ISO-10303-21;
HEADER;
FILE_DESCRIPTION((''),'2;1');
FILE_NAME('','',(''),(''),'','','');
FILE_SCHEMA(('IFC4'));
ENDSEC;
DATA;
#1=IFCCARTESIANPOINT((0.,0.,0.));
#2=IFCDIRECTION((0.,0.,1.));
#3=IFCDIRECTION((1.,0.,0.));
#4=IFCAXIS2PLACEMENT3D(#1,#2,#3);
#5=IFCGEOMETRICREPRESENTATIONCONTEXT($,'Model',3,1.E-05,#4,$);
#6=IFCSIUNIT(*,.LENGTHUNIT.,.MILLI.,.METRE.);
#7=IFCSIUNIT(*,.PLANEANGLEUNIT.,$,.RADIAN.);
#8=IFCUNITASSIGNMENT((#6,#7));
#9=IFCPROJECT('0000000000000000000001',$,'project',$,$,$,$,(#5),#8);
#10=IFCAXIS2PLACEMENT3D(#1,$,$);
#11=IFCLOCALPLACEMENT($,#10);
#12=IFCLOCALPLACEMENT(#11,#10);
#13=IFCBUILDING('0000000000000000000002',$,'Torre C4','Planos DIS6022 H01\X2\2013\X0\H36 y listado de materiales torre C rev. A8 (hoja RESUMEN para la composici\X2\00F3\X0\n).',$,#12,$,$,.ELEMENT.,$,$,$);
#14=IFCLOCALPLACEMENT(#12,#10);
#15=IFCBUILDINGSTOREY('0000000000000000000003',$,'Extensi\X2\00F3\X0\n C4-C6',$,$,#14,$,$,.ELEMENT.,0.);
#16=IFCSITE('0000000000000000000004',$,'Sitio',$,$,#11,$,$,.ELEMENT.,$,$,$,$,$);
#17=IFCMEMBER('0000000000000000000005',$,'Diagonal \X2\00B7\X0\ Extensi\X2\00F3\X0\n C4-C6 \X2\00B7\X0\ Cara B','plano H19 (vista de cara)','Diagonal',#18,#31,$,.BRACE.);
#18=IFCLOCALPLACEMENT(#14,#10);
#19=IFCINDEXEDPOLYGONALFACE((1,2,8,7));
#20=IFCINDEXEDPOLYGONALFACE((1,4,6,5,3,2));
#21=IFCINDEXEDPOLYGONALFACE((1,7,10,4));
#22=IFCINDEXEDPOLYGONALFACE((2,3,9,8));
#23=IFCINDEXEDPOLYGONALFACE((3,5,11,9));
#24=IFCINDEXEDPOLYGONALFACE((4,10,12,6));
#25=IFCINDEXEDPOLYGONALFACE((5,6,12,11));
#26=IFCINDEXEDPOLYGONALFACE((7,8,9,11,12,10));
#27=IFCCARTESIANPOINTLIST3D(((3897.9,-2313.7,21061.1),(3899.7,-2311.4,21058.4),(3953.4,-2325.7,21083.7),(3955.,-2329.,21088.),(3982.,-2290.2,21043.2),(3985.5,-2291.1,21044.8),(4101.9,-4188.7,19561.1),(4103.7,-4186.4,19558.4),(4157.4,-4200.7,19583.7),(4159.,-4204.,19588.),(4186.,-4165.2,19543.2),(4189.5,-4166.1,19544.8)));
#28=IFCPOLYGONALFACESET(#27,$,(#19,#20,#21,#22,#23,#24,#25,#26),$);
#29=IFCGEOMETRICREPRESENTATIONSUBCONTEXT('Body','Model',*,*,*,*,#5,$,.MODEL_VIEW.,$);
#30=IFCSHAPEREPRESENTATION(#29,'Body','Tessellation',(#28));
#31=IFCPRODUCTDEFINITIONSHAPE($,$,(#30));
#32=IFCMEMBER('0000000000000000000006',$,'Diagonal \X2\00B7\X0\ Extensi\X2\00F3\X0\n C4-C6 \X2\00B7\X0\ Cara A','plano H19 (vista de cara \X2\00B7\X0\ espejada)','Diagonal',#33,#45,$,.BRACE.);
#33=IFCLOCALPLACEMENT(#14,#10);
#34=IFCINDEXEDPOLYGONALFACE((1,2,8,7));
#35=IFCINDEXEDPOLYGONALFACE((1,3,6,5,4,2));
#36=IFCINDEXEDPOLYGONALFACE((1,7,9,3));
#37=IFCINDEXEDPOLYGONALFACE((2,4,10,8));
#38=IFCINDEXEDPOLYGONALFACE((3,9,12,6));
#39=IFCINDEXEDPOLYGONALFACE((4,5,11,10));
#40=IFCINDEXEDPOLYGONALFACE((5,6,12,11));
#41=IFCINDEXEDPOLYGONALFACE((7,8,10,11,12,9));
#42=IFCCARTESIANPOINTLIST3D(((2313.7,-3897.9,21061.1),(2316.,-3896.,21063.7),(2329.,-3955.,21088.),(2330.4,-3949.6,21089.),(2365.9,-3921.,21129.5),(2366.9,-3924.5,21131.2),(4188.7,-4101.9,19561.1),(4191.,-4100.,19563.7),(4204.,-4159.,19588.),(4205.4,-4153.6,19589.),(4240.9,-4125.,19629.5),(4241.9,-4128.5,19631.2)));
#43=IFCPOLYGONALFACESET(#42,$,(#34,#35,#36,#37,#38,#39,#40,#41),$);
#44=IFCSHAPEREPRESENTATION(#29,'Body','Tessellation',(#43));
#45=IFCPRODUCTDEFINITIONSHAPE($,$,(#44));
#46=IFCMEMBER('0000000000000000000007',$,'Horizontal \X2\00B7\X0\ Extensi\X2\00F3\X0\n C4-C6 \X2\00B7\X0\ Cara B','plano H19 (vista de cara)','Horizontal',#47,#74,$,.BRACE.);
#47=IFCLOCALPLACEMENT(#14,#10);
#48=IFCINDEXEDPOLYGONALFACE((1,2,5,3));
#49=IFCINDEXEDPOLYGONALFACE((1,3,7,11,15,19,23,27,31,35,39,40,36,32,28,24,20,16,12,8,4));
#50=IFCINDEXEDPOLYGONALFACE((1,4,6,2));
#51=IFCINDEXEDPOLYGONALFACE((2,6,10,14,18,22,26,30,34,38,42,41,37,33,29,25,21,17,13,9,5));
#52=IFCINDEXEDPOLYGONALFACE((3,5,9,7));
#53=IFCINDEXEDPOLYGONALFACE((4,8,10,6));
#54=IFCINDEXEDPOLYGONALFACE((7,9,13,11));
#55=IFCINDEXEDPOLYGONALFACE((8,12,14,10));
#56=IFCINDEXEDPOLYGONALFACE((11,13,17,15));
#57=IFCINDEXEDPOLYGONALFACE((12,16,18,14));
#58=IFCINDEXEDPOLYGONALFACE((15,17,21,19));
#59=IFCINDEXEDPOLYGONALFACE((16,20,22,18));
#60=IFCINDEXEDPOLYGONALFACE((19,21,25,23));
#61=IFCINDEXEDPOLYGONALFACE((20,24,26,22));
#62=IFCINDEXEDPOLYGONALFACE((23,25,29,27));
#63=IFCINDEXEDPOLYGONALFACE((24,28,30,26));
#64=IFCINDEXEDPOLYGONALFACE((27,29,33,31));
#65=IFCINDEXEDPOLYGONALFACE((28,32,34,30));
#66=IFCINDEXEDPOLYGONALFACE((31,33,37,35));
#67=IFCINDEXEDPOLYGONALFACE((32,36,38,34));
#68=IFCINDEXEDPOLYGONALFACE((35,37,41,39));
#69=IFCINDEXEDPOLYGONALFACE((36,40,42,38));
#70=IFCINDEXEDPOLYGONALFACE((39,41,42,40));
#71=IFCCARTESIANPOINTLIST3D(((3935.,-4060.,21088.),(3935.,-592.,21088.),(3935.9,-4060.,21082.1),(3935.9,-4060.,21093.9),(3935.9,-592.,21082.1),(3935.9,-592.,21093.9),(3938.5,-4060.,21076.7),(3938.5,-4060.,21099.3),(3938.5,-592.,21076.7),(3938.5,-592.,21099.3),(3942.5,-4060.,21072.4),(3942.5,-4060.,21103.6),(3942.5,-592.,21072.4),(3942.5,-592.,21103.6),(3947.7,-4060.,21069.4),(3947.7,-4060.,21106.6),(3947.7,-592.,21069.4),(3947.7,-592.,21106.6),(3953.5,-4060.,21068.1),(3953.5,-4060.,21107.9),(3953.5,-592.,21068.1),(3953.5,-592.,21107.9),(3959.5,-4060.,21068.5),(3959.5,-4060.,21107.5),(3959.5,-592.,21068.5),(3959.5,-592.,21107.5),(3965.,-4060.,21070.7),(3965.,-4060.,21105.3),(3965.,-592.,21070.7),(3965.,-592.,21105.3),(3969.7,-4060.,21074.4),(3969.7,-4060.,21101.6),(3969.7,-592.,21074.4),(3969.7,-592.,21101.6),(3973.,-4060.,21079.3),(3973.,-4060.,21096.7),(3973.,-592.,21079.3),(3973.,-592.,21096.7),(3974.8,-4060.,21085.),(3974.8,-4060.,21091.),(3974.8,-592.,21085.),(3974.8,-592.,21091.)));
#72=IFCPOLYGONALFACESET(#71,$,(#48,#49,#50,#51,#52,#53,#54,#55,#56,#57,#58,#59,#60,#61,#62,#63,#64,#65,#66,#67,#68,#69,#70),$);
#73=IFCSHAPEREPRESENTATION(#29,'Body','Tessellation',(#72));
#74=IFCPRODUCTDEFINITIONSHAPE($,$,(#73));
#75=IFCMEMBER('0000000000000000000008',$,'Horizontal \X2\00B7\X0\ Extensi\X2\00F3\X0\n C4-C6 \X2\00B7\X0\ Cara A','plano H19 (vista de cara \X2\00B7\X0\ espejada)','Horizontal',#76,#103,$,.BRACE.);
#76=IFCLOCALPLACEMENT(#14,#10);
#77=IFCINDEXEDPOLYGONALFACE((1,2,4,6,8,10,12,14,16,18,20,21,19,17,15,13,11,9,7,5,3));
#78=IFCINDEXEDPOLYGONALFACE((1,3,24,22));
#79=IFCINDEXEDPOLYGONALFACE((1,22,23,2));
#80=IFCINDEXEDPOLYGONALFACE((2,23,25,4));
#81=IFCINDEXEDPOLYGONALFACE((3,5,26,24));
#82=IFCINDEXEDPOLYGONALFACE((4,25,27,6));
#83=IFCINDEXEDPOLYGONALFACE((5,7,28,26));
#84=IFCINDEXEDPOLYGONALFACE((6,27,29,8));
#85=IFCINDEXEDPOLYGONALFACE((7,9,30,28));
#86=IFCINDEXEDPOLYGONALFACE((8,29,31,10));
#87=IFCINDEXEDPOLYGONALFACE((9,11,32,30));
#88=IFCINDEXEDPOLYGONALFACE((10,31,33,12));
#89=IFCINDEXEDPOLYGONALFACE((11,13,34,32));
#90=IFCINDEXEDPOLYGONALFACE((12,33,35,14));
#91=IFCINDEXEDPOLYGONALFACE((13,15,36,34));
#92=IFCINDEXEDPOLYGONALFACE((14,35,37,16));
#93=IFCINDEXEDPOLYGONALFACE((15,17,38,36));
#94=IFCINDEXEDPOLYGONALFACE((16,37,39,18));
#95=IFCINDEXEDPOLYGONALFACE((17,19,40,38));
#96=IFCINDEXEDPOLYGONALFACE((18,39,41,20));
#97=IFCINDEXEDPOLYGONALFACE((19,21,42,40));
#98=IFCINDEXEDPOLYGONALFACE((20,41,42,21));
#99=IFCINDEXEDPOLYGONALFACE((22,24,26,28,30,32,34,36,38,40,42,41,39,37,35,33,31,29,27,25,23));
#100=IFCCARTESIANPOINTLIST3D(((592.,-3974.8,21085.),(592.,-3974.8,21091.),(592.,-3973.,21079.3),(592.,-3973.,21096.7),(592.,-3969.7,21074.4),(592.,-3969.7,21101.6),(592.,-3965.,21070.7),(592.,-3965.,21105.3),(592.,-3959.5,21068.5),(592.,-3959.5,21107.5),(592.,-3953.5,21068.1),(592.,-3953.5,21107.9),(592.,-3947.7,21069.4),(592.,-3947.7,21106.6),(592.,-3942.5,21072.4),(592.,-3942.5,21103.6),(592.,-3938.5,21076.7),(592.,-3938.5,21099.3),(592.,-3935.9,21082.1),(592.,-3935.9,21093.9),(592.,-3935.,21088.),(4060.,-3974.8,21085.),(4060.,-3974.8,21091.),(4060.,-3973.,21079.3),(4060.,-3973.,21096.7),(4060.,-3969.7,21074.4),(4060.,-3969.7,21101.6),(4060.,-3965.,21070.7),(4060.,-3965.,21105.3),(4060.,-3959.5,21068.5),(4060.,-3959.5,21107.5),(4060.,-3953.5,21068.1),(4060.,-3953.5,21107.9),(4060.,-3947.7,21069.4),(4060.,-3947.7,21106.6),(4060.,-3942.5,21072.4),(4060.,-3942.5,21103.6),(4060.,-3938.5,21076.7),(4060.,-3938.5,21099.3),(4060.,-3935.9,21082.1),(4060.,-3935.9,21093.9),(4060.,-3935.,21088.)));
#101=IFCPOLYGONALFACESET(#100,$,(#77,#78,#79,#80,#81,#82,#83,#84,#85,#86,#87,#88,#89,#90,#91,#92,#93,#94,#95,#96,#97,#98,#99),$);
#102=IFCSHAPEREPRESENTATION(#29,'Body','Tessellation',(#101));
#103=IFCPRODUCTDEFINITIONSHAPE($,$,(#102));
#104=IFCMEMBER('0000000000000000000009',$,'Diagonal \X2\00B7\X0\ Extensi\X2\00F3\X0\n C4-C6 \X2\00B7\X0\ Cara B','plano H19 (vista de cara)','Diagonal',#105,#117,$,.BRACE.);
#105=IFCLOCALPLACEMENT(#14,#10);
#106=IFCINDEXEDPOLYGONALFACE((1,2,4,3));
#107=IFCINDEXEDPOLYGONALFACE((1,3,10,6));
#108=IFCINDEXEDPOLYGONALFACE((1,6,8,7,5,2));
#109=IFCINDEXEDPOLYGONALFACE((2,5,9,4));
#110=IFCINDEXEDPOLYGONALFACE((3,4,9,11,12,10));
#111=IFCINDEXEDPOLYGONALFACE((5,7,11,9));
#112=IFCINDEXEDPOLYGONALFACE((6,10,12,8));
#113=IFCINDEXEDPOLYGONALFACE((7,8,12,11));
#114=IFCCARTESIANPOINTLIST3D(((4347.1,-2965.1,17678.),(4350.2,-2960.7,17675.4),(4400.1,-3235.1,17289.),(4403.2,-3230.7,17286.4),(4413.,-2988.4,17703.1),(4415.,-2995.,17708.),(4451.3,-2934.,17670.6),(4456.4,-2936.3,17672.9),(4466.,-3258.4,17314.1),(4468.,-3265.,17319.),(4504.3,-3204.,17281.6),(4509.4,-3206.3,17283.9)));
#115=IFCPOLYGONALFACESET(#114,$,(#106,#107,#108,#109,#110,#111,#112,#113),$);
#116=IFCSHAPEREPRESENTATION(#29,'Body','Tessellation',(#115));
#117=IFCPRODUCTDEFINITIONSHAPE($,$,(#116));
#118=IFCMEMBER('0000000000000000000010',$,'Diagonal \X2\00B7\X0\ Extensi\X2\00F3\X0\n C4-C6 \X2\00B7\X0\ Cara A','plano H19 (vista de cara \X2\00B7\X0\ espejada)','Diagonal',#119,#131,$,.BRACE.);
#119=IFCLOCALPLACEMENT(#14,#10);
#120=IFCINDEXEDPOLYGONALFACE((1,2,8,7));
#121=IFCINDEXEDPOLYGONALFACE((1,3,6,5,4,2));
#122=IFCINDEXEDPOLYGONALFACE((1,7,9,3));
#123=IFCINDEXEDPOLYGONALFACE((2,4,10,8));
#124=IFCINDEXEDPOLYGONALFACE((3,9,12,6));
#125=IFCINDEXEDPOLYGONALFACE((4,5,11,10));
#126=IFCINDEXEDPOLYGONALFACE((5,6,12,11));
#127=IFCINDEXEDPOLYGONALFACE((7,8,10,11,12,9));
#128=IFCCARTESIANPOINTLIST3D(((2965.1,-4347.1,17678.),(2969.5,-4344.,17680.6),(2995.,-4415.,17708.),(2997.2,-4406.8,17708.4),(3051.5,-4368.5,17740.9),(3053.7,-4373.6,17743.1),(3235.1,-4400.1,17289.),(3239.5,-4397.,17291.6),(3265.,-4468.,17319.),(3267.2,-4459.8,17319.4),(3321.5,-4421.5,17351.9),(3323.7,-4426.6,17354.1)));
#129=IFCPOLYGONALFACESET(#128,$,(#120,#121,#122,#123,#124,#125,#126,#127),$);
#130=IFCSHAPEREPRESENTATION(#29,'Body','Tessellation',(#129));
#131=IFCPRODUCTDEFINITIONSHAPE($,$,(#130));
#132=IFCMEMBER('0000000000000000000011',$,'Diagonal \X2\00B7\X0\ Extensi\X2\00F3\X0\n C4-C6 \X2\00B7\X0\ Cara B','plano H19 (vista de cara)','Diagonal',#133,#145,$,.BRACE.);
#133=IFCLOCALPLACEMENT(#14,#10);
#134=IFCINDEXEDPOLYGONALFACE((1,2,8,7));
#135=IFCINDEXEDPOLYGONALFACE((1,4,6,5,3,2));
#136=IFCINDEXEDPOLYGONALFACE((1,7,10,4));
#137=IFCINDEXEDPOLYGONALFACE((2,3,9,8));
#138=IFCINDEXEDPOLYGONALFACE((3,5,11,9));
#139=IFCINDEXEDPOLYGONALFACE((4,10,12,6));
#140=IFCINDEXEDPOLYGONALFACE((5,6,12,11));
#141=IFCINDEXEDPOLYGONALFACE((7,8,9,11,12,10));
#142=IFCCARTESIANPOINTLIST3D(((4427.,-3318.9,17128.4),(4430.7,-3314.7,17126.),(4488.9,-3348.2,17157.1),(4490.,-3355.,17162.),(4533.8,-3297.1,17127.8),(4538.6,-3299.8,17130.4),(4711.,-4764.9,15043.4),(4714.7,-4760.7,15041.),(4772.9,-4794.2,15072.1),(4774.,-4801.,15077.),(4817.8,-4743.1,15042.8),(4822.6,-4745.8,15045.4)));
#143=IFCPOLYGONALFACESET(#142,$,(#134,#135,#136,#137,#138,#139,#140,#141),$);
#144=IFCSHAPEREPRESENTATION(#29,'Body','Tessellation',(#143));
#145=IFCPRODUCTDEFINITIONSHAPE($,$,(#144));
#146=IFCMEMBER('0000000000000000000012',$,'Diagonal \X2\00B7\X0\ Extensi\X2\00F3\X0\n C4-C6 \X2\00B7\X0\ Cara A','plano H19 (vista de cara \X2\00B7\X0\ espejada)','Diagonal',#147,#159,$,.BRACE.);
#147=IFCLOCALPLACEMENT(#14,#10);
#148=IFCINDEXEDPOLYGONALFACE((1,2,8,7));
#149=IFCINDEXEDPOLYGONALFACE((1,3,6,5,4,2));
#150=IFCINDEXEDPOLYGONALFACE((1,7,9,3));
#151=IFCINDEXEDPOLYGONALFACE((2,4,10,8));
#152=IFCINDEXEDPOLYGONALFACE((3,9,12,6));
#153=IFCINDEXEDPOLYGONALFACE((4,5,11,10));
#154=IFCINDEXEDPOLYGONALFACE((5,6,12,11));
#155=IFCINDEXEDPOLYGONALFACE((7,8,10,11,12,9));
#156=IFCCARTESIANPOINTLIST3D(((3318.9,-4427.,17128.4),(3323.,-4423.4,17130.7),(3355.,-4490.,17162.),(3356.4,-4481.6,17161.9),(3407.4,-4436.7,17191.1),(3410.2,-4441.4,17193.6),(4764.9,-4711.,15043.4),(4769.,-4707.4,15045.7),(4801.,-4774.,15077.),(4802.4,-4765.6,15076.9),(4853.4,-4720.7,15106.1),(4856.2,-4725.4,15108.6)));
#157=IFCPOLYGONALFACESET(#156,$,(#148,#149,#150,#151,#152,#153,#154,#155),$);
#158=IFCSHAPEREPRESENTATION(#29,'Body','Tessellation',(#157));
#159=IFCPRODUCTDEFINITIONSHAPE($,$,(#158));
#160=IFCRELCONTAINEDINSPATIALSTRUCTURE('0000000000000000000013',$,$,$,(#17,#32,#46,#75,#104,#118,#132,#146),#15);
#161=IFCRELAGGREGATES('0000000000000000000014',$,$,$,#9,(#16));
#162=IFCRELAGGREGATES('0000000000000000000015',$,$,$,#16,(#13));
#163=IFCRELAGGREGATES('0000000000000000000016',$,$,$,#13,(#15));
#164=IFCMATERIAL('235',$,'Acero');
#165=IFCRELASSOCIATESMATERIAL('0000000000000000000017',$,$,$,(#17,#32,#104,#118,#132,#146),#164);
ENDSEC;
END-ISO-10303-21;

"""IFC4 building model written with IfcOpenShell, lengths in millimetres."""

from ifc_helpers import new_model, si_unit, frame, frame_2d, origin, origin_with_axes, place, context, subcontext, project, spatial, circle, l_section, extrude, material, element, save


model = new_model("IFC4")

# Units and contexts
model_context = context("Model", 3, precision=1e-05, world=origin_with_axes())
body_context = subcontext(model_context, "Body", "Model", "MODEL_VIEW")
ifc_project = project(units=[si_unit("LENGTHUNIT", "METRE", prefix="MILLI"), si_unit("PLANEANGLEUNIT", "RADIAN")], contexts=[model_context])

# Site, building, storey
site_placement = place(None, origin())
site = spatial("IfcSite", under=ifc_project, at=site_placement, Name="Sitio", CompositionType="ELEMENT")
building_placement = place(site_placement, origin())
building = spatial("IfcBuilding", under=site, at=building_placement, Name="Torre C4", Description="Planos DIS6022 H01–H36 y listado de materiales torre C rev. A8 (hoja RESUMEN para la composición).", CompositionType="ELEMENT")
storey_placement = place(building_placement, origin())
storey = spatial("IfcBuildingStorey", under=building, at=storey_placement, Name="Extensión C4-C6", CompositionType="ELEMENT", Elevation=0.0)

# Members
ifc_material = material(Name="235", Category="Acero")
for number, where, z_axis, x_axis, name, description in (
    (1, (3955.0, -2329.0, 21088.0), (0.084654, -0.778066, -0.622453), (-0.879209, 0.235619, -0.414097), "Diagonal · Extensión C4-C6 · Cara B", "plano H19 (vista de cara)"),
    (2, (2329.0, -3955.0, 21088.0), (0.778066, -0.084654, -0.622453), (-0.235619, 0.879209, -0.414097), "Diagonal · Extensión C4-C6 · Cara A", "plano H19 (vista de cara · espejada)"),
):
    element("IfcMember", number, at=place(storey_placement, frame(where, z_axis=z_axis, x_axis=x_axis)), inside=storey, material=ifc_material, Name=name, Description=description, ObjectType="Diagonal", PredefinedType="BRACE", context=body_context, shape_type="SweptSolid", body=[
        extrude(l_section(Depth=65.0, Width=65.0, Thickness=4.0, at=frame_2d((32.5, 32.5))), None, (0.0, 0.0, 1.0), 2409.8),
    ])
for number, where, z_axis, x_axis, name, description in (
    (3, (3955.0, -592.0, 21088.0), (0.0, -1.0, 0.0), (-1.0, 0.0, 0.0), "Horizontal · Extensión C4-C6 · Cara B", "plano H19 (vista de cara)"),
    (4, (592.0, -3955.0, 21088.0), (1.0, 0.0, 0.0), (0.0, 1.0, 0.0), "Horizontal · Extensión C4-C6 · Cara A", "plano H19 (vista de cara · espejada)"),
):
    element("IfcMember", number, at=place(storey_placement, frame(where, z_axis=z_axis, x_axis=x_axis)), inside=storey, Name=name, Description=description, ObjectType="Horizontal", PredefinedType="BRACE", context=body_context, shape_type="SweptSolid", body=[
        extrude(circle(Radius=20.0), None, (0.0, 0.0, 1.0), 3468.0),
    ])
for number, where, z_axis, x_axis, name, description in (
    (5, (4415.0, -2995.0, 17708.0), (0.111233, -0.566659, -0.816409), (-0.848414, 0.37365, -0.37494), "Diagonal · Extensión C4-C6 · Cara B", "plano H19 (vista de cara)"),
    (6, (2995.0, -4415.0, 17708.0), (0.566659, -0.111233, -0.816409), (-0.37365, 0.848414, -0.37494), "Diagonal · Extensión C4-C6 · Cara A", "plano H19 (vista de cara · espejada)"),
):
    element("IfcMember", number, at=place(storey_placement, frame(where, z_axis=z_axis, x_axis=x_axis)), inside=storey, material=ifc_material, Name=name, Description=description, ObjectType="Diagonal", PredefinedType="BRACE", context=body_context, shape_type="SweptSolid", body=[
        extrude(l_section(Depth=80.0, Width=80.0, Thickness=6.0, at=frame_2d((40.0, 40.0))), None, (0.0, 0.0, 1.0), 476.5),
    ])
for number, where, z_axis, x_axis, name, description in (
    (7, (4490.0, -3355.0, 17162.0), (0.111233, -0.56635, -0.816624), (-0.786928, 0.451653, -0.420421), "Diagonal · Extensión C4-C6 · Cara B", "plano H19 (vista de cara)"),
    (8, (3355.0, -4490.0, 17162.0), (0.56635, -0.111233, -0.816624), (-0.451653, 0.786928, -0.420421), "Diagonal · Extensión C4-C6 · Cara A", "plano H19 (vista de cara · espejada)"),
):
    element("IfcMember", number, at=place(storey_placement, frame(where, z_axis=z_axis, x_axis=x_axis)), inside=storey, material=ifc_material, Name=name, Description=description, ObjectType="Diagonal", PredefinedType="BRACE", context=body_context, shape_type="SweptSolid", body=[
        extrude(l_section(Depth=80.0, Width=80.0, Thickness=6.0, at=frame_2d((40.0, 40.0))), None, (0.0, 0.0, 1.0), 2553.2),
    ])

save(model, "model.ifc")
